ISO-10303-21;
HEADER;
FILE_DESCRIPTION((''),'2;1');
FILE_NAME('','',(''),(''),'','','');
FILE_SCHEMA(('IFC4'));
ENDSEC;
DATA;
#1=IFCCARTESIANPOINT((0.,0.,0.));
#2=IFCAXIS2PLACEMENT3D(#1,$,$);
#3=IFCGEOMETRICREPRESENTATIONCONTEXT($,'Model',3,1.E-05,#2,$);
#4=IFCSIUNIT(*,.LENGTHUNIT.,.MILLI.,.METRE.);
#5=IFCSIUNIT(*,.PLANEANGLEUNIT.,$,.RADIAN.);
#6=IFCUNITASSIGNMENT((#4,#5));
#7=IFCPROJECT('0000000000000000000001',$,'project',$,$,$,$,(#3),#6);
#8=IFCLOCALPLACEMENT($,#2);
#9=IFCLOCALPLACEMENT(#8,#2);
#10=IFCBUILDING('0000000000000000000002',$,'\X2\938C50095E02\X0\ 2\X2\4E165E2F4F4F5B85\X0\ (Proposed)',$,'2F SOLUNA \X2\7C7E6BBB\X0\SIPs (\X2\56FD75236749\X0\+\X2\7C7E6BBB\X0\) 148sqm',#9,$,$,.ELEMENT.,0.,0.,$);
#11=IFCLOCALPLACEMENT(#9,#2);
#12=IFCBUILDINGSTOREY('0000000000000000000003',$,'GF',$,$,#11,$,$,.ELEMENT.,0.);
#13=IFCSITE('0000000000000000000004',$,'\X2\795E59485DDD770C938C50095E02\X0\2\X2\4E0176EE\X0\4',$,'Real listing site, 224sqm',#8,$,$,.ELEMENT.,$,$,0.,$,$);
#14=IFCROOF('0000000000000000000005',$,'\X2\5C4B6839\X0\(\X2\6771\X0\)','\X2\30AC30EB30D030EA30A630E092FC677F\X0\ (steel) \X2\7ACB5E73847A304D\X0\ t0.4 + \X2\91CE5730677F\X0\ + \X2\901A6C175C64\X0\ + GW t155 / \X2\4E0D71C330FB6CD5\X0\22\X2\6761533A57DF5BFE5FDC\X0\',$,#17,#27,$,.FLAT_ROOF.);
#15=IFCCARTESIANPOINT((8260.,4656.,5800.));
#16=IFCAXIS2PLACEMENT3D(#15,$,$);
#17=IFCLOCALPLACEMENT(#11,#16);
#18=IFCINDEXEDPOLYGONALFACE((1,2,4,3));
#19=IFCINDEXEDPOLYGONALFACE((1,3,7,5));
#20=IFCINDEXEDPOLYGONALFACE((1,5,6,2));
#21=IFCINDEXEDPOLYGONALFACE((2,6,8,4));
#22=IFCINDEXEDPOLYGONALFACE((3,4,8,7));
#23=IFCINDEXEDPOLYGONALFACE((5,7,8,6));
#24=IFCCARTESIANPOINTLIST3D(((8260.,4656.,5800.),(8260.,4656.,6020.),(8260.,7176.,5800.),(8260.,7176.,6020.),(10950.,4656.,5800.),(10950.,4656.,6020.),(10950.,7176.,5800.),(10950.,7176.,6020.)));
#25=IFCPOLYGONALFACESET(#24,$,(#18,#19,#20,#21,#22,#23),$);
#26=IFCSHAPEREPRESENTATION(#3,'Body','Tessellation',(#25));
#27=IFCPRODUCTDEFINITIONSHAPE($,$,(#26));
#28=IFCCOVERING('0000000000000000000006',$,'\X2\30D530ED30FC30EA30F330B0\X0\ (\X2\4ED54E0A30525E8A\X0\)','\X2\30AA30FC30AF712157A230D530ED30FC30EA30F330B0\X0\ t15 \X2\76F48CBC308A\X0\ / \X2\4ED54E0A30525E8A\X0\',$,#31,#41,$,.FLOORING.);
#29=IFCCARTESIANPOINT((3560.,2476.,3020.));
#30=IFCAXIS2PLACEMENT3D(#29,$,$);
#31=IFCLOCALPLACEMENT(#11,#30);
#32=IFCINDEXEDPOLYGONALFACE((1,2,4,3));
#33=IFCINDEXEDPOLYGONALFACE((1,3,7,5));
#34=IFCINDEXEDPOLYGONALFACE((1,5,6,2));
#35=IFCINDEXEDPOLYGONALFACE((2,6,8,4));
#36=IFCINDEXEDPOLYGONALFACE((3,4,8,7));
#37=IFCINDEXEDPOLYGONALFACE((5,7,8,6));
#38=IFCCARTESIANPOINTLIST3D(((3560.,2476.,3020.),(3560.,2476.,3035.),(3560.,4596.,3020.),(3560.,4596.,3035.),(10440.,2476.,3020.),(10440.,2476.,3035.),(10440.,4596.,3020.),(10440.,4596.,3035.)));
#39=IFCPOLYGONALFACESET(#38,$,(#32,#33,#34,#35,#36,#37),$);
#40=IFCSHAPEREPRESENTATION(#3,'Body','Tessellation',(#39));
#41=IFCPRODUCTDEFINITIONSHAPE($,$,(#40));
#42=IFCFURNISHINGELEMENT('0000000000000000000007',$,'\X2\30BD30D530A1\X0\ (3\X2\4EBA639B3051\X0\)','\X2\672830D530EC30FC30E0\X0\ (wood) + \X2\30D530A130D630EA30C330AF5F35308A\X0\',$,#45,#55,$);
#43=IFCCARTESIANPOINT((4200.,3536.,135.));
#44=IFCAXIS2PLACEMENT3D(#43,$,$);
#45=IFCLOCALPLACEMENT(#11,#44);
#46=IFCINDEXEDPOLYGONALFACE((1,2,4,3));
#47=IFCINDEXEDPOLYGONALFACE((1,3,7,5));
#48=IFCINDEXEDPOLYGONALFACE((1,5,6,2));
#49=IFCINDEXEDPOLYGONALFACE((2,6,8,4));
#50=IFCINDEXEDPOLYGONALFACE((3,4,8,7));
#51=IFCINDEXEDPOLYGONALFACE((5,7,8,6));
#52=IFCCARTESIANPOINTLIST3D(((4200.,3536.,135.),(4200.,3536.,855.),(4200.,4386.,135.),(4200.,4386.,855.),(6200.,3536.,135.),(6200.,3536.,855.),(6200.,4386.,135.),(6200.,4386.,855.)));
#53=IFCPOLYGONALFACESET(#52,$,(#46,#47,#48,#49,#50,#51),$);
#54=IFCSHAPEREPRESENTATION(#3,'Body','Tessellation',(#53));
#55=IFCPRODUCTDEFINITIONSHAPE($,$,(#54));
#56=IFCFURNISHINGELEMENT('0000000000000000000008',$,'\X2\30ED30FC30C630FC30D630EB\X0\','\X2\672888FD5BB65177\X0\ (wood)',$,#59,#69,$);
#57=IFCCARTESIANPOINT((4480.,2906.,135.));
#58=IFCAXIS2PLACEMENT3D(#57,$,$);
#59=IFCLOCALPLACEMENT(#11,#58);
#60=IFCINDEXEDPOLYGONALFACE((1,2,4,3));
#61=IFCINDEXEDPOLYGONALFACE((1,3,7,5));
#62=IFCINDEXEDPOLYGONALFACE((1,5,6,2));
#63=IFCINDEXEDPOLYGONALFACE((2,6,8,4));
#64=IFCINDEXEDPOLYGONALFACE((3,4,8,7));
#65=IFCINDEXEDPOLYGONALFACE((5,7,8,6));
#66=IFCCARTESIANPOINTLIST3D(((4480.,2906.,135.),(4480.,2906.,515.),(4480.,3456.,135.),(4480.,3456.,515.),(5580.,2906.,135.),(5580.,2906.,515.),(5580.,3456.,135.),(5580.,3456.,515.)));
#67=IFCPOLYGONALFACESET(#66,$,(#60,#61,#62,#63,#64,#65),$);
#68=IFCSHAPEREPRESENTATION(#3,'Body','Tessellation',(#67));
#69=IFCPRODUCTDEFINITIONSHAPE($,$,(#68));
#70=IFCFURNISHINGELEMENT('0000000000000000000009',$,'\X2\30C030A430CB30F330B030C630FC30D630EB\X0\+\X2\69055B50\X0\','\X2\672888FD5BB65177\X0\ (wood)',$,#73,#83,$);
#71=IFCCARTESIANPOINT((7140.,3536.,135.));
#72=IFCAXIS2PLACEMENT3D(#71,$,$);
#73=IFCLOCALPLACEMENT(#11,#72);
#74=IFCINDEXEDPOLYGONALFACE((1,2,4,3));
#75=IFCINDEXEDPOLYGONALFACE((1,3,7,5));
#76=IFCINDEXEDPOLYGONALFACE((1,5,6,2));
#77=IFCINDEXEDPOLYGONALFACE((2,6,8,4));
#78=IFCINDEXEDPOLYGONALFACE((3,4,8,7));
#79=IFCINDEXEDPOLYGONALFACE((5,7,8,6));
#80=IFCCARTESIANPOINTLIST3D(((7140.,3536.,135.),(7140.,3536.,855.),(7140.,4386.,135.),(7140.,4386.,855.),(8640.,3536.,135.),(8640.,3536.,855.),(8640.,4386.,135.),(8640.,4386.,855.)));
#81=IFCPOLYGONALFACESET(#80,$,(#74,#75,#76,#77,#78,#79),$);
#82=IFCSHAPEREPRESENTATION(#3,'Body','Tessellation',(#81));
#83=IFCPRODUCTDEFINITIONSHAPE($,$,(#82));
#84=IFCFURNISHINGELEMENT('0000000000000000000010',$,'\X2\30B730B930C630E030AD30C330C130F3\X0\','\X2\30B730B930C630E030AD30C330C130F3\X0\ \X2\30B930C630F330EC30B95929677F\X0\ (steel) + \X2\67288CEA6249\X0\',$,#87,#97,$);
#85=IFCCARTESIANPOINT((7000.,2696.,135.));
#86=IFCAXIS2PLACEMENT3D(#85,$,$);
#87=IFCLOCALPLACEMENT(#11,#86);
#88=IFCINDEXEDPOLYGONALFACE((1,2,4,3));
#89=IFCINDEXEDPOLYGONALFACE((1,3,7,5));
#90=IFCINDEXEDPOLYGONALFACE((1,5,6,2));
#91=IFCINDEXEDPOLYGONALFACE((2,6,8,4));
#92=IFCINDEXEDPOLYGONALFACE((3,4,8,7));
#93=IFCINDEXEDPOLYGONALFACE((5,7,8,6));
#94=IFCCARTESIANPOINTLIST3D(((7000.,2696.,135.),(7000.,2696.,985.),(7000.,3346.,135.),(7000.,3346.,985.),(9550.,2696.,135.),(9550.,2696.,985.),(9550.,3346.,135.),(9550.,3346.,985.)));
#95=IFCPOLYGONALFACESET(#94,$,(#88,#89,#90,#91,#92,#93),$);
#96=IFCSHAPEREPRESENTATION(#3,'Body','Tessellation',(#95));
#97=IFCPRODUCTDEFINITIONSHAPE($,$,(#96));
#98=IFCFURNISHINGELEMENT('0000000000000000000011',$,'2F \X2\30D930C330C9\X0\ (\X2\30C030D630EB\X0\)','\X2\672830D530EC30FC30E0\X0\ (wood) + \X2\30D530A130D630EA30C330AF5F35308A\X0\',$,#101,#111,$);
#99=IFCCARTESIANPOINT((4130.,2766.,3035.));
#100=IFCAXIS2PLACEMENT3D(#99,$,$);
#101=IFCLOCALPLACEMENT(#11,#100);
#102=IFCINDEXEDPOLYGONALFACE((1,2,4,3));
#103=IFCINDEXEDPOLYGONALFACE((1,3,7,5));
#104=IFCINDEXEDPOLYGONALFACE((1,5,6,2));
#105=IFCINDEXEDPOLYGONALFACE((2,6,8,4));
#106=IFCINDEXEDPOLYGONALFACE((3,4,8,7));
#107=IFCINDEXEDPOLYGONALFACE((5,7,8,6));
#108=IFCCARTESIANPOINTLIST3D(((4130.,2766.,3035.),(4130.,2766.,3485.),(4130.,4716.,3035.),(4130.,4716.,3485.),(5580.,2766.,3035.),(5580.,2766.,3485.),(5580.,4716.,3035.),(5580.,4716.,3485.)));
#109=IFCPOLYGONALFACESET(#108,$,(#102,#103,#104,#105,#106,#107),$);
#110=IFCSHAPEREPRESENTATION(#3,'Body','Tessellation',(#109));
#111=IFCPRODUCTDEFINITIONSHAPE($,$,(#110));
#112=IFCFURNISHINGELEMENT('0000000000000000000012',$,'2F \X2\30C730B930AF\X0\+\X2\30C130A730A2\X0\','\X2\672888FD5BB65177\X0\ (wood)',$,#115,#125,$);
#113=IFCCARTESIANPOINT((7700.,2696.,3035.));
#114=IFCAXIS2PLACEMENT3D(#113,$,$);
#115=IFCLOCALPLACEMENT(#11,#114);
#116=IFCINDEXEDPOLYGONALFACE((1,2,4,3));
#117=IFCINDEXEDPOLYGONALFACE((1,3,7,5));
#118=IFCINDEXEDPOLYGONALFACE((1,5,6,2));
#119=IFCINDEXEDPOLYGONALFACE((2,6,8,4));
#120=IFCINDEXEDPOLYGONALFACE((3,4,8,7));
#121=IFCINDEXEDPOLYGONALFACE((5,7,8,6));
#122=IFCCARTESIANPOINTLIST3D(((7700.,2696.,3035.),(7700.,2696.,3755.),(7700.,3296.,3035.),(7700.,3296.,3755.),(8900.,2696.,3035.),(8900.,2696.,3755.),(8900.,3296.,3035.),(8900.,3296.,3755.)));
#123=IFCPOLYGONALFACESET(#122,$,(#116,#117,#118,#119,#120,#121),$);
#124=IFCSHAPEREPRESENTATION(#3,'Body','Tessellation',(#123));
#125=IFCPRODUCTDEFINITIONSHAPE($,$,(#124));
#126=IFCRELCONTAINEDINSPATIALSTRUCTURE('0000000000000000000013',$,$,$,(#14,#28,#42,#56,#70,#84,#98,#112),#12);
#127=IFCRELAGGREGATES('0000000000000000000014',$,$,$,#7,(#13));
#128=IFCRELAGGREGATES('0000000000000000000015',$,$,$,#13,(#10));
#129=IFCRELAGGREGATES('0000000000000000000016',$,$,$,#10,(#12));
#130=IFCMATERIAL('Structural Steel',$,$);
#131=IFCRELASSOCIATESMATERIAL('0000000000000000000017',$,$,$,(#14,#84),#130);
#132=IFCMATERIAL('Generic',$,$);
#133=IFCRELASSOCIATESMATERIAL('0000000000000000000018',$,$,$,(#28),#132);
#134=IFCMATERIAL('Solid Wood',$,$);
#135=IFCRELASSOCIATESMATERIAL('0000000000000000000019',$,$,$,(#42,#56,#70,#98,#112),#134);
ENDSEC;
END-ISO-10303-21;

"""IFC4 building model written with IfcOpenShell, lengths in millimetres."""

from ifc_helpers import new_model, si_unit, frame, frame_2d, origin, place, context, project, spatial, rectangle, extrude, material, element, save


model = new_model("IFC4")

# Units and contexts
model_context = context("Model", 3, precision=1e-05, world=origin())
ifc_project = project(units=[si_unit("LENGTHUNIT", "METRE", prefix="MILLI"), si_unit("PLANEANGLEUNIT", "RADIAN")], contexts=[model_context])

# Site, building, storey
site_placement = place(None, origin())
site = spatial("IfcSite", under=ifc_project, at=site_placement, Name="神奈川県鎌倉市2丁目4", ObjectType="Real listing site, 224sqm", CompositionType="ELEMENT", RefElevation=0.0)
building_placement = place(site_placement, origin())
building = spatial("IfcBuilding", under=site, at=building_placement, Name="鎌倉市 2世帯住宅 (Proposed)", ObjectType="2F SOLUNA 籾殻SIPs (国産杉+籾殻) 148sqm", CompositionType="ELEMENT", ElevationOfRefHeight=0.0, ElevationOfTerrain=0.0)
storey_placement = place(building_placement, origin())
storey = spatial("IfcBuildingStorey", under=building, at=storey_placement, Name="GF", CompositionType="ELEMENT", Elevation=0.0)

# Shared definitions
ifc_material_1 = material(Name="Solid Wood")

# Shared definitions
ifc_material_2 = material(Name="Generic")

# Roof
ifc_material_3 = material(Name="Structural Steel")
roof_placement = place(storey_placement, frame((8260.0, 4656.0, 5800.0)))
element("IfcRoof", 1, at=roof_placement, inside=storey, material=ifc_material_3, Name="屋根(東)", Description="ガルバリウム鋼板 (steel) 立平葺き t0.4 + 野地板 + 通気層 + GW t155 / 不燃・法22条区域対応", PredefinedType="FLAT_ROOF", context=model_context, shape_type="SweptSolid", body=[
    extrude(rectangle(XDim=2690.0, YDim=2520.0, at=frame_2d((1345.0, 1260.0))), frame((8260.0, 4656.0, 5800.0)), (0.0, 0.0, 1.0), 220.0),
])

# Covering
covering_placement = place(storey_placement, frame((3560.0, 2476.0, 3020.0)))
element("IfcCovering", 2, at=covering_placement, inside=storey, material=ifc_material_2, Name="フローリング (仕上げ床)", Description="オーク無垢フローリング t15 直貼り / 仕上げ床", PredefinedType="FLOORING", context=model_context, shape_type="SweptSolid", body=[
    extrude(rectangle(XDim=6880.0, YDim=2120.0, at=frame_2d((3440.0, 1060.0))), frame((3560.0, 2476.0, 3020.0)), (0.0, 0.0, 1.0), 15.0),
])

# Furnishing elements
furnishing_1_placement = place(storey_placement, frame((4200.0, 3536.0, 135.0)))
element("IfcFurnishingElement", 3, at=furnishing_1_placement, inside=storey, material=ifc_material_1, Name="ソファ (3人掛け)", Description="木フレーム (wood) + ファブリック張り", context=model_context, shape_type="SweptSolid", body=[
    extrude(rectangle(XDim=2000.0, YDim=850.0, at=frame_2d((1000.0, 425.0))), frame((4200.0, 3536.0, 135.0)), (0.0, 0.0, 1.0), 720.0),
])
furnishing_2_placement = place(storey_placement, frame((4480.0, 2906.0, 135.0)))
element("IfcFurnishingElement", 4, at=furnishing_2_placement, inside=storey, material=ifc_material_1, Name="ローテーブル", Description="木製家具 (wood)", context=model_context, shape_type="SweptSolid", body=[
    extrude(rectangle(XDim=1100.0, YDim=550.0, at=frame_2d((550.0, 275.0))), frame((4480.0, 2906.0, 135.0)), (0.0, 0.0, 1.0), 380.0),
])
furnishing_3_placement = place(storey_placement, frame((7140.0, 3536.0, 135.0)))
element("IfcFurnishingElement", 5, at=furnishing_3_placement, inside=storey, material=ifc_material_1, Name="ダイニングテーブル+椅子", Description="木製家具 (wood)", context=model_context, shape_type="SweptSolid", body=[
    extrude(rectangle(XDim=1500.0, YDim=850.0, at=frame_2d((750.0, 425.0))), frame((7140.0, 3536.0, 135.0)), (0.0, 0.0, 1.0), 720.0),
])
furnishing_4_placement = place(storey_placement, frame((7000.0, 2696.0, 135.0)))
element("IfcFurnishingElement", 6, at=furnishing_4_placement, inside=storey, material=ifc_material_3, Name="システムキッチン", Description="システムキッチン ステンレス天板 (steel) + 木質扉", context=model_context, shape_type="SweptSolid", body=[
    extrude(rectangle(XDim=2550.0, YDim=650.0, at=frame_2d((1275.0, 325.0))), frame((7000.0, 2696.0, 135.0)), (0.0, 0.0, 1.0), 850.0),
])
furnishing_5_placement = place(storey_placement, frame((4130.0, 2766.0, 3035.0)))
element("IfcFurnishingElement", 7, at=furnishing_5_placement, inside=storey, material=ifc_material_1, Name="2F ベッド (ダブル)", Description="木フレーム (wood) + ファブリック張り", context=model_context, shape_type="SweptSolid", body=[
    extrude(rectangle(XDim=1450.0, YDim=1950.0, at=frame_2d((725.0, 975.0))), frame((4130.0, 2766.0, 3035.0)), (0.0, 0.0, 1.0), 450.0),
])
furnishing_6_placement = place(storey_placement, frame((7700.0, 2696.0, 3035.0)))
element("IfcFurnishingElement", 8, at=furnishing_6_placement, inside=storey, material=ifc_material_1, Name="2F デスク+チェア", Description="木製家具 (wood)", context=model_context, shape_type="SweptSolid", body=[
    extrude(rectangle(XDim=1200.0, YDim=600.0, at=frame_2d((600.0, 300.0))), frame((7700.0, 2696.0, 3035.0)), (0.0, 0.0, 1.0), 720.0),
])

save(model, "model.ifc")
